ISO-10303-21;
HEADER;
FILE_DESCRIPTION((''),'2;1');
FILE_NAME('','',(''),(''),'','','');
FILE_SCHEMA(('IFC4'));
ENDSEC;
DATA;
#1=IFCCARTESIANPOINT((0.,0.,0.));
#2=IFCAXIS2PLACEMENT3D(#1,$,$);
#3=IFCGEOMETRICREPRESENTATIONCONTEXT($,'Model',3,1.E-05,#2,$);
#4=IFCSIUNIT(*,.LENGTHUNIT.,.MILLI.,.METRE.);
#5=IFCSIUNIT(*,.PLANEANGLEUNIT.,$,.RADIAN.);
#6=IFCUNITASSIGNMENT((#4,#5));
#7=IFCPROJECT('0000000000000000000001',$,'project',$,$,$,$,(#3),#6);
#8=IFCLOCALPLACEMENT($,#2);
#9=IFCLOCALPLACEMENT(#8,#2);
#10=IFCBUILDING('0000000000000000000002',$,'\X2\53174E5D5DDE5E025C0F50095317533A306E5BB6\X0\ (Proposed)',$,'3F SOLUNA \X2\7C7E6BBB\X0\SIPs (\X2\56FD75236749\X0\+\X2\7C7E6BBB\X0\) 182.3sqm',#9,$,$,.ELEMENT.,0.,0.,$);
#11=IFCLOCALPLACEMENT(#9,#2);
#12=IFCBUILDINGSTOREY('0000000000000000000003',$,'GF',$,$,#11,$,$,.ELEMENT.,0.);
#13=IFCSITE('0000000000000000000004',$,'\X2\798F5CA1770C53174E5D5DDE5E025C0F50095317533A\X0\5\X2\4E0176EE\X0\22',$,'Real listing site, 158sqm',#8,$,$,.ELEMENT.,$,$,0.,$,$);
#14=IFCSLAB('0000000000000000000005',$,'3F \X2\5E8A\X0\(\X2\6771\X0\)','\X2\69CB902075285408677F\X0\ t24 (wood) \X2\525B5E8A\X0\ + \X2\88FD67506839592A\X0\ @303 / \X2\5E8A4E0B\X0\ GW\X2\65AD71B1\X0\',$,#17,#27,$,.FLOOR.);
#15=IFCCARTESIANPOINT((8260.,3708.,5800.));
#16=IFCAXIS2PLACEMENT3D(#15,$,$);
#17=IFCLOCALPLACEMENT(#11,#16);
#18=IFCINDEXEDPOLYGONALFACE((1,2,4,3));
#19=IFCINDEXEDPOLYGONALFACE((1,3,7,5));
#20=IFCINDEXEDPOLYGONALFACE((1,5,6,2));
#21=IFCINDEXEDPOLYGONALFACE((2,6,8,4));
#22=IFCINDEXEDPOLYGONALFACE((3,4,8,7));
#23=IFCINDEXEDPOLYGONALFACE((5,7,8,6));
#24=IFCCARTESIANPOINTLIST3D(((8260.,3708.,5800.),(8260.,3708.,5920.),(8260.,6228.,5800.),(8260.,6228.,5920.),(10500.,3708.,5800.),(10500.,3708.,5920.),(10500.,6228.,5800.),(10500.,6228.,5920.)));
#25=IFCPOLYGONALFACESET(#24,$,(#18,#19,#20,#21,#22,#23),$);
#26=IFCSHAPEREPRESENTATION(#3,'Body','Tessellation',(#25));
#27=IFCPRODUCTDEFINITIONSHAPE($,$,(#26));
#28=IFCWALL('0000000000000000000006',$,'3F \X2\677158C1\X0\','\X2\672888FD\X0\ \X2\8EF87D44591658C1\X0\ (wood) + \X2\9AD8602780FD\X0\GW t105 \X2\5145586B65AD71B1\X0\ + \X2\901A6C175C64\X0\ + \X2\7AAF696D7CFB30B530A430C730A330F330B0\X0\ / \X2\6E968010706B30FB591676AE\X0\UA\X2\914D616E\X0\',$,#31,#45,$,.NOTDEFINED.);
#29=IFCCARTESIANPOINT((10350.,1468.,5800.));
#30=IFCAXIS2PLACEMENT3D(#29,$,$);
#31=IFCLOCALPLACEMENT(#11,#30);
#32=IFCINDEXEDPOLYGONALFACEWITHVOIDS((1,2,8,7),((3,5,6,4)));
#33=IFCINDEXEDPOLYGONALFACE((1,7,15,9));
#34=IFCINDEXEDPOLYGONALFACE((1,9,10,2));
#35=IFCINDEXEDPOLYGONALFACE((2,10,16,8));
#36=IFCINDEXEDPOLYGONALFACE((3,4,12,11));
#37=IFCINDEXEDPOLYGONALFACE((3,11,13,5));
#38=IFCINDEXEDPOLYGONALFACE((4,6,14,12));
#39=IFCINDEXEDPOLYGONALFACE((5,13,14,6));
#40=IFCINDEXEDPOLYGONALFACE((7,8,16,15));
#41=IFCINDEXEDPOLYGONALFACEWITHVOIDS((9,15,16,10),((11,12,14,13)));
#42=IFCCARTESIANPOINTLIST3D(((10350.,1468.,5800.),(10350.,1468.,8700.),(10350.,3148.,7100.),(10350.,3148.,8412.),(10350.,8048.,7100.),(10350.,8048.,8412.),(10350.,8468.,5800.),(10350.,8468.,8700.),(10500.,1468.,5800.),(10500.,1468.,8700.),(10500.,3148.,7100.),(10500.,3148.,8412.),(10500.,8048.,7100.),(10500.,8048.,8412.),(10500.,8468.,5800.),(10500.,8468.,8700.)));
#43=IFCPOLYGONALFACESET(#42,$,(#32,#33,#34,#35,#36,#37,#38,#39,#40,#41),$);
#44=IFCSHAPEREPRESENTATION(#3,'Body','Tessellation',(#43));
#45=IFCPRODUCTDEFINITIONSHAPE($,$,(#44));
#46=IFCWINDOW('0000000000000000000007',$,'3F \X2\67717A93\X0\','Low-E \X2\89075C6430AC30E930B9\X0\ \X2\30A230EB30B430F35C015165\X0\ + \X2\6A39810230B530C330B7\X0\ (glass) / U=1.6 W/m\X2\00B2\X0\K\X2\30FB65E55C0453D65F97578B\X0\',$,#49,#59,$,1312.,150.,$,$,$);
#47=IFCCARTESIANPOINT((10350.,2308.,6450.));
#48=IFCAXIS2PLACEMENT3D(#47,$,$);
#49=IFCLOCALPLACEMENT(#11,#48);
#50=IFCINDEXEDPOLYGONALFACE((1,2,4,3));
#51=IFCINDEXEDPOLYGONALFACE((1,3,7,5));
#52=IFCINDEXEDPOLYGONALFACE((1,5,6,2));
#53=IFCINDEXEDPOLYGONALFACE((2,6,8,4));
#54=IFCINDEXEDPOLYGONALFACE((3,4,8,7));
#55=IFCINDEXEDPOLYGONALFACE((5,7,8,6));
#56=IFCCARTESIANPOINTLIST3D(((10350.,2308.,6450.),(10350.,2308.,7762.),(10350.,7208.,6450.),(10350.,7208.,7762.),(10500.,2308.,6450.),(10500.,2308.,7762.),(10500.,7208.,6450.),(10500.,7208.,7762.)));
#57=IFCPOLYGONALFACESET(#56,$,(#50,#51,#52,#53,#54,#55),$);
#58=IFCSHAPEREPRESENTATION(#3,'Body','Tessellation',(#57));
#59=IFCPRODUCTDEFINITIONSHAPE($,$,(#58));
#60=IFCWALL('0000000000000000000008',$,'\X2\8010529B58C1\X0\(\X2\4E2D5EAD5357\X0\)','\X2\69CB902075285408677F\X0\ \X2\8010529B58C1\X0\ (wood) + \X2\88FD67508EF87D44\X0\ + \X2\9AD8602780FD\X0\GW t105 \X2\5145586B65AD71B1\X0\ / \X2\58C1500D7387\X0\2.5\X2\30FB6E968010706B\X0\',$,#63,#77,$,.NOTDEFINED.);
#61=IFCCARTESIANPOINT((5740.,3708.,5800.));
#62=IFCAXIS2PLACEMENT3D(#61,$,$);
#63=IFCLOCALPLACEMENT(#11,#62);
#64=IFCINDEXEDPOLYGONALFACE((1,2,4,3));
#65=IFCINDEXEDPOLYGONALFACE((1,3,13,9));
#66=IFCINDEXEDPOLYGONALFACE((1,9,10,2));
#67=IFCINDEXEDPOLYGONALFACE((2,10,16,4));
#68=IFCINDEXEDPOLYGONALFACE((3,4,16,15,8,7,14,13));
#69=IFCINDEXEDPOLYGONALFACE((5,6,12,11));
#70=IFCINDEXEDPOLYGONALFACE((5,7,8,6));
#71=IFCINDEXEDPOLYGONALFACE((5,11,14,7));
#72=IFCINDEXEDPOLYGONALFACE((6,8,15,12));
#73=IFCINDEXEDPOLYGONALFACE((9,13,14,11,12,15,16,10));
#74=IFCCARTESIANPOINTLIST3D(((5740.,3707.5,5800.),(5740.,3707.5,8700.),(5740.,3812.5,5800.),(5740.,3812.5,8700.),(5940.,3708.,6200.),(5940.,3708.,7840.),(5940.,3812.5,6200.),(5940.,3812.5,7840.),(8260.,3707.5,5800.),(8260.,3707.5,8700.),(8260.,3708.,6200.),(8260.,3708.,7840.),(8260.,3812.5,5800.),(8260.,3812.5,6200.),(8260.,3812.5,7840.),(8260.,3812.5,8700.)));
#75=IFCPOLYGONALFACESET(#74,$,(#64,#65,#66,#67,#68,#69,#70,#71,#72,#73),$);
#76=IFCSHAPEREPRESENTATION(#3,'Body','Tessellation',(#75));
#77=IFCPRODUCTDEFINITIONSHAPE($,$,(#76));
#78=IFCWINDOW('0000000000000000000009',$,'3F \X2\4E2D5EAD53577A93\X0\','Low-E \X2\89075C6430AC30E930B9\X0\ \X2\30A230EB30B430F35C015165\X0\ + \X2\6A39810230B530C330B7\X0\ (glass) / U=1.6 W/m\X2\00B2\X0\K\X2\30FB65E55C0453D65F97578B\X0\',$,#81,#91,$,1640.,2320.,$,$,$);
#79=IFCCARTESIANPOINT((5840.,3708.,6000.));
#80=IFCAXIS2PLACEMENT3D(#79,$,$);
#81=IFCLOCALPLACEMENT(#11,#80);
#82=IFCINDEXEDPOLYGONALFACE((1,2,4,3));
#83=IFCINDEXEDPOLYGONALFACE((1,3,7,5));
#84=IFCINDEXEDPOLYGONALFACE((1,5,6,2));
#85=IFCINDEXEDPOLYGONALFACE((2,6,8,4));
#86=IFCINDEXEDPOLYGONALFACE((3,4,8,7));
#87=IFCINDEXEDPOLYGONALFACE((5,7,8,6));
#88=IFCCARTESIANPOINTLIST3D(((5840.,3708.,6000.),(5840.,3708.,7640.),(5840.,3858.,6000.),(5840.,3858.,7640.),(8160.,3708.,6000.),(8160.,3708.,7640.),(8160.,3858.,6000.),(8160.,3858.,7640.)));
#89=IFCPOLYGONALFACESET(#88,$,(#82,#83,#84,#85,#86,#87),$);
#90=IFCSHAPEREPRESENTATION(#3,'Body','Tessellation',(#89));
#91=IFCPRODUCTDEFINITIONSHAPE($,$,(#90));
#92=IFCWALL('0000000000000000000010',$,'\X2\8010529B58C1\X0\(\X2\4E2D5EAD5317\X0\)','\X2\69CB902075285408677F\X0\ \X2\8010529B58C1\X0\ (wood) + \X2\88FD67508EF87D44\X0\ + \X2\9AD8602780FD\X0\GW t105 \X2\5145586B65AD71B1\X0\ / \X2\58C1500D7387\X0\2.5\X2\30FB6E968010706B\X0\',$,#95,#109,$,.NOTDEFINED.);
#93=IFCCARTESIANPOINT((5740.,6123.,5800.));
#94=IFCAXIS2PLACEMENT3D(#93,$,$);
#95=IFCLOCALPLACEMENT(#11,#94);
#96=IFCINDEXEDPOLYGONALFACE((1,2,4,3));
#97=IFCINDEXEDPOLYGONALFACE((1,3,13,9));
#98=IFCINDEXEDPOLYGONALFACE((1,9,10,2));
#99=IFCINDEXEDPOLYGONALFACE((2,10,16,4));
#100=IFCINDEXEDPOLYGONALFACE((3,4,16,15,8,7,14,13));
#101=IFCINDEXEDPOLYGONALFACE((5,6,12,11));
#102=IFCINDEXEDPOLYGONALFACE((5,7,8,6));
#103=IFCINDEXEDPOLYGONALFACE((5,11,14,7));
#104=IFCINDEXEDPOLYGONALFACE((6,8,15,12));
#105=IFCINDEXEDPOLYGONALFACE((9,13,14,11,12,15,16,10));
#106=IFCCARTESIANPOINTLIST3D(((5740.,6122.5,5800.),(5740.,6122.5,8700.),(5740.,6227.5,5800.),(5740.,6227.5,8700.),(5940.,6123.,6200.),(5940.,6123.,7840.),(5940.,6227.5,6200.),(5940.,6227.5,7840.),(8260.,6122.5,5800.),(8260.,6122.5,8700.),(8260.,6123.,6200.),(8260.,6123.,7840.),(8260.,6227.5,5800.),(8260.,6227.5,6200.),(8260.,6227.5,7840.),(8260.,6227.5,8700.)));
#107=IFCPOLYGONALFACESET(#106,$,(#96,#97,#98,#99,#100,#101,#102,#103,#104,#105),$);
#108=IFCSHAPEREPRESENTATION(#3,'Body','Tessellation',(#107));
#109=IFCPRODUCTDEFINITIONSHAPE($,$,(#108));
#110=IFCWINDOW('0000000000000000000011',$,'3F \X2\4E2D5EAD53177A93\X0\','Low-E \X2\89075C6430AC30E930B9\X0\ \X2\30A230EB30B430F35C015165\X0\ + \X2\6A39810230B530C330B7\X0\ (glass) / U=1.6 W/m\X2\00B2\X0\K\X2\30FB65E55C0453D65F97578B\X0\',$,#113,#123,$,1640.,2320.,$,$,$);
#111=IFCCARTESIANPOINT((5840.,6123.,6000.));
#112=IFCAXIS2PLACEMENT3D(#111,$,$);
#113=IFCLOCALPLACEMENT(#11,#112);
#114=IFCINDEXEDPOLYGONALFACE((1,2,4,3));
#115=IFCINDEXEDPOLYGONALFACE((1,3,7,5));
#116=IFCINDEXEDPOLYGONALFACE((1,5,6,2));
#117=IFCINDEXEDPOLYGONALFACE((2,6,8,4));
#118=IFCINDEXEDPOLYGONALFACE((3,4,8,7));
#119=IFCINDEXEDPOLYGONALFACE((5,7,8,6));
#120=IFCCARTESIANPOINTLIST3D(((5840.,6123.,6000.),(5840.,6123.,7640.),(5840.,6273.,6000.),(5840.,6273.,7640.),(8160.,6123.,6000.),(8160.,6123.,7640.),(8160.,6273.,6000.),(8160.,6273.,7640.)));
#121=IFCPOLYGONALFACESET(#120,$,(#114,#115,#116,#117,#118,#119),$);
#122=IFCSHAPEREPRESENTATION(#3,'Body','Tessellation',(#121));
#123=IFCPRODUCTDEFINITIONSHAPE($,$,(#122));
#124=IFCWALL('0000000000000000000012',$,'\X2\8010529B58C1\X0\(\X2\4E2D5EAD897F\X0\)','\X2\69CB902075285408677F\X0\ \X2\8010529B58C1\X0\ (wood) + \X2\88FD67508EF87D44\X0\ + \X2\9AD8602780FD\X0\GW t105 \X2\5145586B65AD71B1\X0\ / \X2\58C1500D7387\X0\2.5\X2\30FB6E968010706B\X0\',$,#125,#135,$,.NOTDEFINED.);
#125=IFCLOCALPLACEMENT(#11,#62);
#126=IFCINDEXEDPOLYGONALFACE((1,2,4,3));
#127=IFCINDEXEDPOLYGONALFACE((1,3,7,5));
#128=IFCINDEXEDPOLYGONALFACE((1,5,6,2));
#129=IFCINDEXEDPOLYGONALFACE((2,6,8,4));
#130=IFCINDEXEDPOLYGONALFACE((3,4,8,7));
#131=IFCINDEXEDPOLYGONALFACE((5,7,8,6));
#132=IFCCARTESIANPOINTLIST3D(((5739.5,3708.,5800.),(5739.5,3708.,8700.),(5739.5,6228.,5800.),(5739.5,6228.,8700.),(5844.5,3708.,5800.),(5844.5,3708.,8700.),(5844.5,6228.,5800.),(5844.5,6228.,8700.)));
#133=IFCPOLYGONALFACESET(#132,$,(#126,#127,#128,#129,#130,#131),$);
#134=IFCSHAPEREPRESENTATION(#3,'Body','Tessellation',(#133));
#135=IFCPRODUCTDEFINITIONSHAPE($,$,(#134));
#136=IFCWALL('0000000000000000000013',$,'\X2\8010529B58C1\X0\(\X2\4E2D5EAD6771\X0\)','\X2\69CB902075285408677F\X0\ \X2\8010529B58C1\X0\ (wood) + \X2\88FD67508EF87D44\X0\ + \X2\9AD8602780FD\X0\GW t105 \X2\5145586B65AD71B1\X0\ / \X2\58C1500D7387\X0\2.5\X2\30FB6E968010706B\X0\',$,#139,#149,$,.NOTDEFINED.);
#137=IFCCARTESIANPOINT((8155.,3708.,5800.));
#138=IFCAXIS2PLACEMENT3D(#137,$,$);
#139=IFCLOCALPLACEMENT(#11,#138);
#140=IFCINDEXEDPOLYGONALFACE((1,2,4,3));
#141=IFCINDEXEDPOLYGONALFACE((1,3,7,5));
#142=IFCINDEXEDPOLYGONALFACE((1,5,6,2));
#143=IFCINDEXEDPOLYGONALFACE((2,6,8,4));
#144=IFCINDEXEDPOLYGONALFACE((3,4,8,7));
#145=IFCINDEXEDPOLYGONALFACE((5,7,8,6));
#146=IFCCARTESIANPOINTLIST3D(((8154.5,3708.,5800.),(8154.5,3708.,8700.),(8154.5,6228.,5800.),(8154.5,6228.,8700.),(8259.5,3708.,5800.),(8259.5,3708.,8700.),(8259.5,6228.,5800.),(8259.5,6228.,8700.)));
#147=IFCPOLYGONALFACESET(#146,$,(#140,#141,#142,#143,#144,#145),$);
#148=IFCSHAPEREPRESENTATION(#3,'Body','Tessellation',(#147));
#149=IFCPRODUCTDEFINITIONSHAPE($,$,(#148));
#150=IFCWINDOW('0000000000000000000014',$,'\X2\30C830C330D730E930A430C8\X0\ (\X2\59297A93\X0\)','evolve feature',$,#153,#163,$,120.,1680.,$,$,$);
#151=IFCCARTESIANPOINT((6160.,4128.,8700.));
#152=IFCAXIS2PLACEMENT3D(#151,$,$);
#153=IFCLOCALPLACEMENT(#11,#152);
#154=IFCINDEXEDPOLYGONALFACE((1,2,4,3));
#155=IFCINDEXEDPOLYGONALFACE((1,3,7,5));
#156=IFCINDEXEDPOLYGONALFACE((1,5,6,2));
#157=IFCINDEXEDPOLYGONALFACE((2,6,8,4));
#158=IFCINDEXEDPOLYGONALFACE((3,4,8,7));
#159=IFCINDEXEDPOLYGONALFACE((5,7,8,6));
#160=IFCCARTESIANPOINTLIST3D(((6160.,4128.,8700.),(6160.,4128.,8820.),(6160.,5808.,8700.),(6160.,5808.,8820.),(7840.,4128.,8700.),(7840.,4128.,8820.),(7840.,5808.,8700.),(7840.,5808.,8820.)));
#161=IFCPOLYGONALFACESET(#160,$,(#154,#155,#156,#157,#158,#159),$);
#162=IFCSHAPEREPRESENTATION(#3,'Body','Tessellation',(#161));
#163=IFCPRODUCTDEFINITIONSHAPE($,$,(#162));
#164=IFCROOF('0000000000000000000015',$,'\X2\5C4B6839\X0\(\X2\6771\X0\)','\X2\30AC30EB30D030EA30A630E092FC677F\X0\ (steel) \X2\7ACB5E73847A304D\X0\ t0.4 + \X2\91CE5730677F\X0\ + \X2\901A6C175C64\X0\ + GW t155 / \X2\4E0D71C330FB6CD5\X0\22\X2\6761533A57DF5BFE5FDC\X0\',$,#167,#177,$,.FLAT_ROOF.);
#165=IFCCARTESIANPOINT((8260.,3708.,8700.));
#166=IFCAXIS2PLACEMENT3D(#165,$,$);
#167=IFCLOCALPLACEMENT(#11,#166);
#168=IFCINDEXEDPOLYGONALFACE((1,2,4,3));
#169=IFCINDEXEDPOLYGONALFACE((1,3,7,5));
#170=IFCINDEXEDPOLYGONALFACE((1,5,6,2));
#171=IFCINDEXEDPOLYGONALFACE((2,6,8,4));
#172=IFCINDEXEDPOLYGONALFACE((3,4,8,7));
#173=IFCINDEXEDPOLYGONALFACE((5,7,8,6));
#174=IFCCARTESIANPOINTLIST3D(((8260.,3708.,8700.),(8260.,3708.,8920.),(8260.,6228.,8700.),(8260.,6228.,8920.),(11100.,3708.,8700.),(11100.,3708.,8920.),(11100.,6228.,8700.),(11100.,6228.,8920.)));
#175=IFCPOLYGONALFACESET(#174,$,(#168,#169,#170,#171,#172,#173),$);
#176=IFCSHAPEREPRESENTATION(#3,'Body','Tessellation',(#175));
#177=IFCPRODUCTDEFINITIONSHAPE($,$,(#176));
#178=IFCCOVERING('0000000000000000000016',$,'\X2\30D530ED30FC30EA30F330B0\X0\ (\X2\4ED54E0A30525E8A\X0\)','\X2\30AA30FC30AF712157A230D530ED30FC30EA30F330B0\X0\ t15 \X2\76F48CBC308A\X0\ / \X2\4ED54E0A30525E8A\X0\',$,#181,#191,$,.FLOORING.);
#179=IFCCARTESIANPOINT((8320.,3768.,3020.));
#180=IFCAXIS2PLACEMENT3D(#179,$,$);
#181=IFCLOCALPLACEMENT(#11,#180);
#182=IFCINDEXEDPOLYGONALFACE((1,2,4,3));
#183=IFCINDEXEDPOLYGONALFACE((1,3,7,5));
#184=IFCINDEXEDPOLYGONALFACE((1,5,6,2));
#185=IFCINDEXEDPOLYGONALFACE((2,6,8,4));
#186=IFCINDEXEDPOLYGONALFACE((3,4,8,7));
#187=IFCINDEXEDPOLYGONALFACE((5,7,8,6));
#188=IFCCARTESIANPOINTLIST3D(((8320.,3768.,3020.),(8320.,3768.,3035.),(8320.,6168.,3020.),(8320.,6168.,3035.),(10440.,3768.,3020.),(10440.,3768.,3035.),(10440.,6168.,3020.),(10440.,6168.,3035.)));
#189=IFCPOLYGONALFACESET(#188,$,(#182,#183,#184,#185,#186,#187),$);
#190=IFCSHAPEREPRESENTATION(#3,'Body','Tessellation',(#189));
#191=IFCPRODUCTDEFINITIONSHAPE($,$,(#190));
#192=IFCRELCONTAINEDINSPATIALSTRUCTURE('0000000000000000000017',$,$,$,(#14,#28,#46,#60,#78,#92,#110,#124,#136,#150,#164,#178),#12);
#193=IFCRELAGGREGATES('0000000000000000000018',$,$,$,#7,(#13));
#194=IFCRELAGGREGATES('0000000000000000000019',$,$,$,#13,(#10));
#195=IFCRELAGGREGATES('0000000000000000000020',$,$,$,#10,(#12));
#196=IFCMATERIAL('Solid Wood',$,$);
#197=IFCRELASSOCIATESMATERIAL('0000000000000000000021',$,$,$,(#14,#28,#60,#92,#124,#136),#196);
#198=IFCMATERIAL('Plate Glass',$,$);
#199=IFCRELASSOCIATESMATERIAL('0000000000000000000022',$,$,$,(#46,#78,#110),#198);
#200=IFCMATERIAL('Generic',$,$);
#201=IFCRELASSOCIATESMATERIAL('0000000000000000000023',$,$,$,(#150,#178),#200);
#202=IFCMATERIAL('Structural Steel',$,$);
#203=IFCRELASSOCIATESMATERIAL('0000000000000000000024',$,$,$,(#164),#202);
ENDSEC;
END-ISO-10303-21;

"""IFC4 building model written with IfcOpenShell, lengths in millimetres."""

from ifc_helpers import new_model, si_unit, frame, frame_2d, origin, place, context, project, spatial, rectangle, extrude, material, element, fill, save


model = new_model("IFC4")

# Units and contexts
model_context = context("Model", 3, precision=1e-05, world=origin())
ifc_project = project(units=[si_unit("LENGTHUNIT", "METRE", prefix="MILLI"), si_unit("PLANEANGLEUNIT", "RADIAN")], contexts=[model_context])

# Site, building, storey
site_placement = place(None, origin())
site = spatial("IfcSite", under=ifc_project, at=site_placement, Name="福岡県北九州市小倉北区5丁目22", ObjectType="Real listing site, 158sqm", CompositionType="ELEMENT", RefElevation=0.0)
building_placement = place(site_placement, origin())
building = spatial("IfcBuilding", under=site, at=building_placement, Name="北九州市小倉北区の家 (Proposed)", ObjectType="3F SOLUNA 籾殻SIPs (国産杉+籾殻) 182.3sqm", CompositionType="ELEMENT", ElevationOfRefHeight=0.0, ElevationOfTerrain=0.0)
storey_placement = place(building_placement, origin())
storey = spatial("IfcBuildingStorey", under=building, at=storey_placement, Name="GF", CompositionType="ELEMENT", Elevation=0.0)

# Slab
ifc_material_1 = material(Name="Solid Wood")
slab_placement = place(storey_placement, frame((8260.0, 3708.0, 5800.0)))
element("IfcSlab", 1, at=slab_placement, inside=storey, material=ifc_material_1, Name="3F 床(東)", Description="構造用合板 t24 (wood) 剛床 + 製材根太 @303 / 床下 GW断熱", PredefinedType="FLOOR", context=model_context, shape_type="SweptSolid", body=[
    extrude(rectangle(XDim=2240.0, YDim=2520.0, at=frame_2d((1120.0, 1260.0))), frame((8260.0, 3708.0, 5800.0)), (0.0, 0.0, 1.0), 120.0),
])

# Walls, openings, windows
wall_1_placement = place(storey_placement, frame((10350.0, 1468.0, 5800.0)))
wall_1 = element("IfcWall", 2, at=wall_1_placement, inside=storey, material=ifc_material_1, Name="3F 東壁", Description="木製 軸組外壁 (wood) + 高性能GW t105 充填断熱 + 通気層 + 窯業系サイディング / 準耐火・外皮UA配慮", PredefinedType="NOTDEFINED", context=model_context, shape_type="SweptSolid", body=[
    extrude(rectangle(XDim=150.0, YDim=7000.0, at=frame_2d((75.0, 3500.0))), frame((10350.0, 1468.0, 5800.0)), (0.0, 0.0, 1.0), 2900.0),
])
opening_1_placement = place(storey_placement, frame((10350.0, 2308.0, 6450.0)))
opening_1 = element("IfcOpeningElement", 3, at=opening_1_placement, cuts=wall_1, PredefinedType="NOTDEFINED", context=model_context, shape_type="SweptSolid", body=[
    extrude(rectangle(XDim=150.0, YDim=4900.0, at=frame_2d((75.0, 2450.0))), frame((10350.0, 2308.0, 6450.0)), (0.0, 0.0, 1.0), 1312.0),
])
ifc_material_2 = material(Name="Plate Glass")
window_1_placement = place(storey_placement, frame((10350.0, 2308.0, 6450.0)))
window_1 = element("IfcWindow", 4, at=window_1_placement, inside=storey, material=ifc_material_2, Name="3F 東窓", Description="Low-E 複層ガラス アルゴン封入 + 樹脂サッシ (glass) / U=1.6 W/m²K・日射取得型", OverallHeight=1312.0, OverallWidth=150.0, context=model_context, shape_type="SweptSolid", body=[
    extrude(rectangle(XDim=150.0, YDim=4900.0, at=frame_2d((75.0, 2450.0))), frame((10350.0, 2308.0, 6450.0)), (0.0, 0.0, 1.0), 1312.0),
])
fill(opening_1, window_1)
wall_2_placement = place(storey_placement, frame((5740.0, 3708.0, 5800.0)))
wall_2 = element("IfcWall", 5, at=wall_2_placement, inside=storey, material=ifc_material_1, Name="耐力壁(中庭南)", Description="構造用合板 耐力壁 (wood) + 製材軸組 + 高性能GW t105 充填断熱 / 壁倍率2.5・準耐火", PredefinedType="NOTDEFINED", context=model_context, shape_type="SweptSolid", body=[
    extrude(rectangle(XDim=2520.0, YDim=105.0, at=frame_2d((1260.0, 52.0))), frame((5740.0, 3708.0, 5800.0)), (0.0, 0.0, 1.0), 2900.0),
])
opening_2_placement = place(storey_placement, frame((5840.0, 3708.0, 6000.0)))
opening_2 = element("IfcOpeningElement", 6, at=opening_2_placement, cuts=wall_2, PredefinedType="NOTDEFINED", context=model_context, shape_type="SweptSolid", body=[
    extrude(rectangle(XDim=2320.0, YDim=150.0, at=frame_2d((1160.0, 75.0))), frame((5840.0, 3708.0, 6000.0)), (0.0, 0.0, 1.0), 1640.0),
])
window_2_placement = place(storey_placement, frame((5840.0, 3708.0, 6000.0)))
window_2 = element("IfcWindow", 7, at=window_2_placement, inside=storey, material=ifc_material_2, Name="3F 中庭南窓", Description="Low-E 複層ガラス アルゴン封入 + 樹脂サッシ (glass) / U=1.6 W/m²K・日射取得型", OverallHeight=1640.0, OverallWidth=2320.0, context=model_context, shape_type="SweptSolid", body=[
    extrude(rectangle(XDim=2320.0, YDim=150.0, at=frame_2d((1160.0, 75.0))), frame((5840.0, 3708.0, 6000.0)), (0.0, 0.0, 1.0), 1640.0),
])
fill(opening_2, window_2)
wall_3_placement = place(storey_placement, frame((5740.0, 6123.0, 5800.0)))
wall_3 = element("IfcWall", 8, at=wall_3_placement, inside=storey, material=ifc_material_1, Name="耐力壁(中庭北)", Description="構造用合板 耐力壁 (wood) + 製材軸組 + 高性能GW t105 充填断熱 / 壁倍率2.5・準耐火", PredefinedType="NOTDEFINED", context=model_context, shape_type="SweptSolid", body=[
    extrude(rectangle(XDim=2520.0, YDim=105.0, at=frame_2d((1260.0, 52.0))), frame((5740.0, 6123.0, 5800.0)), (0.0, 0.0, 1.0), 2900.0),
])
opening_3_placement = place(storey_placement, frame((5840.0, 6123.0, 6000.0)))
opening_3 = element("IfcOpeningElement", 9, at=opening_3_placement, cuts=wall_3, PredefinedType="NOTDEFINED", context=model_context, shape_type="SweptSolid", body=[
    extrude(rectangle(XDim=2320.0, YDim=150.0, at=frame_2d((1160.0, 75.0))), frame((5840.0, 6123.0, 6000.0)), (0.0, 0.0, 1.0), 1640.0),
])
window_3_placement = place(storey_placement, frame((5840.0, 6123.0, 6000.0)))
window_3 = element("IfcWindow", 10, at=window_3_placement, inside=storey, material=ifc_material_2, Name="3F 中庭北窓", Description="Low-E 複層ガラス アルゴン封入 + 樹脂サッシ (glass) / U=1.6 W/m²K・日射取得型", OverallHeight=1640.0, OverallWidth=2320.0, context=model_context, shape_type="SweptSolid", body=[
    extrude(rectangle(XDim=2320.0, YDim=150.0, at=frame_2d((1160.0, 75.0))), frame((5840.0, 6123.0, 6000.0)), (0.0, 0.0, 1.0), 1640.0),
])
fill(opening_3, window_3)

# Walls
wall_4_placement = place(storey_placement, frame((5740.0, 3708.0, 5800.0)))
element("IfcWall", 11, at=wall_4_placement, inside=storey, material=ifc_material_1, Name="耐力壁(中庭西)", Description="構造用合板 耐力壁 (wood) + 製材軸組 + 高性能GW t105 充填断熱 / 壁倍率2.5・準耐火", PredefinedType="NOTDEFINED", context=model_context, shape_type="SweptSolid", body=[
    extrude(rectangle(XDim=105.0, YDim=2520.0, at=frame_2d((52.0, 1260.0))), frame((5740.0, 3708.0, 5800.0)), (0.0, 0.0, 1.0), 2900.0),
])
wall_5_placement = place(storey_placement, frame((8155.0, 3708.0, 5800.0)))
element("IfcWall", 12, at=wall_5_placement, inside=storey, material=ifc_material_1, Name="耐力壁(中庭東)", Description="構造用合板 耐力壁 (wood) + 製材軸組 + 高性能GW t105 充填断熱 / 壁倍率2.5・準耐火", PredefinedType="NOTDEFINED", context=model_context, shape_type="SweptSolid", body=[
    extrude(rectangle(XDim=105.0, YDim=2520.0, at=frame_2d((52.0, 1260.0))), frame((8155.0, 3708.0, 5800.0)), (0.0, 0.0, 1.0), 2900.0),
])

# Window
ifc_material_3 = material(Name="Generic")
window_4_placement = place(storey_placement, frame((6160.0, 4128.0, 8700.0)))
element("IfcWindow", 13, at=window_4_placement, inside=storey, material=ifc_material_3, Name="トップライト (天窓)", Description="evolve feature", OverallHeight=120.0, OverallWidth=1680.0, context=model_context, shape_type="SweptSolid", body=[
    extrude(rectangle(XDim=1680.0, YDim=1680.0, at=frame_2d((840.0, 840.0))), frame((6160.0, 4128.0, 8700.0)), (0.0, 0.0, 1.0), 120.0),
])

# Roof
ifc_material_4 = material(Name="Structural Steel")
for number, where, name in (
    (14, (8260.0, 3708.0, 8700.0), "屋根(東)"),
):
    element("IfcRoof", number, at=place(storey_placement, frame(where)), inside=storey, material=ifc_material_4, Name=name, Description="ガルバリウム鋼板 (steel) 立平葺き t0.4 + 野地板 + 通気層 + GW t155 / 不燃・法22条区域対応", PredefinedType="FLAT_ROOF", context=model_context, shape_type="SweptSolid", body=[
        extrude(rectangle(XDim=2840.0, YDim=2520.0, at=frame_2d((1420.0, 1260.0))), frame((8260.0, 3708.0, 8700.0)), (0.0, 0.0, 1.0), 220.0),
    ])

# Covering
covering_1_placement = place(storey_placement, frame((8320.0, 3768.0, 3020.0)))
element("IfcCovering", 15, at=covering_1_placement, inside=storey, material=ifc_material_3, Name="フローリング (仕上げ床)", Description="オーク無垢フローリング t15 直貼り / 仕上げ床", PredefinedType="FLOORING", context=model_context, shape_type="SweptSolid", body=[
    extrude(rectangle(XDim=2120.0, YDim=2400.0, at=frame_2d((1060.0, 1200.0))), frame((8320.0, 3768.0, 3020.0)), (0.0, 0.0, 1.0), 15.0),
])

save(model, "model.ifc")
